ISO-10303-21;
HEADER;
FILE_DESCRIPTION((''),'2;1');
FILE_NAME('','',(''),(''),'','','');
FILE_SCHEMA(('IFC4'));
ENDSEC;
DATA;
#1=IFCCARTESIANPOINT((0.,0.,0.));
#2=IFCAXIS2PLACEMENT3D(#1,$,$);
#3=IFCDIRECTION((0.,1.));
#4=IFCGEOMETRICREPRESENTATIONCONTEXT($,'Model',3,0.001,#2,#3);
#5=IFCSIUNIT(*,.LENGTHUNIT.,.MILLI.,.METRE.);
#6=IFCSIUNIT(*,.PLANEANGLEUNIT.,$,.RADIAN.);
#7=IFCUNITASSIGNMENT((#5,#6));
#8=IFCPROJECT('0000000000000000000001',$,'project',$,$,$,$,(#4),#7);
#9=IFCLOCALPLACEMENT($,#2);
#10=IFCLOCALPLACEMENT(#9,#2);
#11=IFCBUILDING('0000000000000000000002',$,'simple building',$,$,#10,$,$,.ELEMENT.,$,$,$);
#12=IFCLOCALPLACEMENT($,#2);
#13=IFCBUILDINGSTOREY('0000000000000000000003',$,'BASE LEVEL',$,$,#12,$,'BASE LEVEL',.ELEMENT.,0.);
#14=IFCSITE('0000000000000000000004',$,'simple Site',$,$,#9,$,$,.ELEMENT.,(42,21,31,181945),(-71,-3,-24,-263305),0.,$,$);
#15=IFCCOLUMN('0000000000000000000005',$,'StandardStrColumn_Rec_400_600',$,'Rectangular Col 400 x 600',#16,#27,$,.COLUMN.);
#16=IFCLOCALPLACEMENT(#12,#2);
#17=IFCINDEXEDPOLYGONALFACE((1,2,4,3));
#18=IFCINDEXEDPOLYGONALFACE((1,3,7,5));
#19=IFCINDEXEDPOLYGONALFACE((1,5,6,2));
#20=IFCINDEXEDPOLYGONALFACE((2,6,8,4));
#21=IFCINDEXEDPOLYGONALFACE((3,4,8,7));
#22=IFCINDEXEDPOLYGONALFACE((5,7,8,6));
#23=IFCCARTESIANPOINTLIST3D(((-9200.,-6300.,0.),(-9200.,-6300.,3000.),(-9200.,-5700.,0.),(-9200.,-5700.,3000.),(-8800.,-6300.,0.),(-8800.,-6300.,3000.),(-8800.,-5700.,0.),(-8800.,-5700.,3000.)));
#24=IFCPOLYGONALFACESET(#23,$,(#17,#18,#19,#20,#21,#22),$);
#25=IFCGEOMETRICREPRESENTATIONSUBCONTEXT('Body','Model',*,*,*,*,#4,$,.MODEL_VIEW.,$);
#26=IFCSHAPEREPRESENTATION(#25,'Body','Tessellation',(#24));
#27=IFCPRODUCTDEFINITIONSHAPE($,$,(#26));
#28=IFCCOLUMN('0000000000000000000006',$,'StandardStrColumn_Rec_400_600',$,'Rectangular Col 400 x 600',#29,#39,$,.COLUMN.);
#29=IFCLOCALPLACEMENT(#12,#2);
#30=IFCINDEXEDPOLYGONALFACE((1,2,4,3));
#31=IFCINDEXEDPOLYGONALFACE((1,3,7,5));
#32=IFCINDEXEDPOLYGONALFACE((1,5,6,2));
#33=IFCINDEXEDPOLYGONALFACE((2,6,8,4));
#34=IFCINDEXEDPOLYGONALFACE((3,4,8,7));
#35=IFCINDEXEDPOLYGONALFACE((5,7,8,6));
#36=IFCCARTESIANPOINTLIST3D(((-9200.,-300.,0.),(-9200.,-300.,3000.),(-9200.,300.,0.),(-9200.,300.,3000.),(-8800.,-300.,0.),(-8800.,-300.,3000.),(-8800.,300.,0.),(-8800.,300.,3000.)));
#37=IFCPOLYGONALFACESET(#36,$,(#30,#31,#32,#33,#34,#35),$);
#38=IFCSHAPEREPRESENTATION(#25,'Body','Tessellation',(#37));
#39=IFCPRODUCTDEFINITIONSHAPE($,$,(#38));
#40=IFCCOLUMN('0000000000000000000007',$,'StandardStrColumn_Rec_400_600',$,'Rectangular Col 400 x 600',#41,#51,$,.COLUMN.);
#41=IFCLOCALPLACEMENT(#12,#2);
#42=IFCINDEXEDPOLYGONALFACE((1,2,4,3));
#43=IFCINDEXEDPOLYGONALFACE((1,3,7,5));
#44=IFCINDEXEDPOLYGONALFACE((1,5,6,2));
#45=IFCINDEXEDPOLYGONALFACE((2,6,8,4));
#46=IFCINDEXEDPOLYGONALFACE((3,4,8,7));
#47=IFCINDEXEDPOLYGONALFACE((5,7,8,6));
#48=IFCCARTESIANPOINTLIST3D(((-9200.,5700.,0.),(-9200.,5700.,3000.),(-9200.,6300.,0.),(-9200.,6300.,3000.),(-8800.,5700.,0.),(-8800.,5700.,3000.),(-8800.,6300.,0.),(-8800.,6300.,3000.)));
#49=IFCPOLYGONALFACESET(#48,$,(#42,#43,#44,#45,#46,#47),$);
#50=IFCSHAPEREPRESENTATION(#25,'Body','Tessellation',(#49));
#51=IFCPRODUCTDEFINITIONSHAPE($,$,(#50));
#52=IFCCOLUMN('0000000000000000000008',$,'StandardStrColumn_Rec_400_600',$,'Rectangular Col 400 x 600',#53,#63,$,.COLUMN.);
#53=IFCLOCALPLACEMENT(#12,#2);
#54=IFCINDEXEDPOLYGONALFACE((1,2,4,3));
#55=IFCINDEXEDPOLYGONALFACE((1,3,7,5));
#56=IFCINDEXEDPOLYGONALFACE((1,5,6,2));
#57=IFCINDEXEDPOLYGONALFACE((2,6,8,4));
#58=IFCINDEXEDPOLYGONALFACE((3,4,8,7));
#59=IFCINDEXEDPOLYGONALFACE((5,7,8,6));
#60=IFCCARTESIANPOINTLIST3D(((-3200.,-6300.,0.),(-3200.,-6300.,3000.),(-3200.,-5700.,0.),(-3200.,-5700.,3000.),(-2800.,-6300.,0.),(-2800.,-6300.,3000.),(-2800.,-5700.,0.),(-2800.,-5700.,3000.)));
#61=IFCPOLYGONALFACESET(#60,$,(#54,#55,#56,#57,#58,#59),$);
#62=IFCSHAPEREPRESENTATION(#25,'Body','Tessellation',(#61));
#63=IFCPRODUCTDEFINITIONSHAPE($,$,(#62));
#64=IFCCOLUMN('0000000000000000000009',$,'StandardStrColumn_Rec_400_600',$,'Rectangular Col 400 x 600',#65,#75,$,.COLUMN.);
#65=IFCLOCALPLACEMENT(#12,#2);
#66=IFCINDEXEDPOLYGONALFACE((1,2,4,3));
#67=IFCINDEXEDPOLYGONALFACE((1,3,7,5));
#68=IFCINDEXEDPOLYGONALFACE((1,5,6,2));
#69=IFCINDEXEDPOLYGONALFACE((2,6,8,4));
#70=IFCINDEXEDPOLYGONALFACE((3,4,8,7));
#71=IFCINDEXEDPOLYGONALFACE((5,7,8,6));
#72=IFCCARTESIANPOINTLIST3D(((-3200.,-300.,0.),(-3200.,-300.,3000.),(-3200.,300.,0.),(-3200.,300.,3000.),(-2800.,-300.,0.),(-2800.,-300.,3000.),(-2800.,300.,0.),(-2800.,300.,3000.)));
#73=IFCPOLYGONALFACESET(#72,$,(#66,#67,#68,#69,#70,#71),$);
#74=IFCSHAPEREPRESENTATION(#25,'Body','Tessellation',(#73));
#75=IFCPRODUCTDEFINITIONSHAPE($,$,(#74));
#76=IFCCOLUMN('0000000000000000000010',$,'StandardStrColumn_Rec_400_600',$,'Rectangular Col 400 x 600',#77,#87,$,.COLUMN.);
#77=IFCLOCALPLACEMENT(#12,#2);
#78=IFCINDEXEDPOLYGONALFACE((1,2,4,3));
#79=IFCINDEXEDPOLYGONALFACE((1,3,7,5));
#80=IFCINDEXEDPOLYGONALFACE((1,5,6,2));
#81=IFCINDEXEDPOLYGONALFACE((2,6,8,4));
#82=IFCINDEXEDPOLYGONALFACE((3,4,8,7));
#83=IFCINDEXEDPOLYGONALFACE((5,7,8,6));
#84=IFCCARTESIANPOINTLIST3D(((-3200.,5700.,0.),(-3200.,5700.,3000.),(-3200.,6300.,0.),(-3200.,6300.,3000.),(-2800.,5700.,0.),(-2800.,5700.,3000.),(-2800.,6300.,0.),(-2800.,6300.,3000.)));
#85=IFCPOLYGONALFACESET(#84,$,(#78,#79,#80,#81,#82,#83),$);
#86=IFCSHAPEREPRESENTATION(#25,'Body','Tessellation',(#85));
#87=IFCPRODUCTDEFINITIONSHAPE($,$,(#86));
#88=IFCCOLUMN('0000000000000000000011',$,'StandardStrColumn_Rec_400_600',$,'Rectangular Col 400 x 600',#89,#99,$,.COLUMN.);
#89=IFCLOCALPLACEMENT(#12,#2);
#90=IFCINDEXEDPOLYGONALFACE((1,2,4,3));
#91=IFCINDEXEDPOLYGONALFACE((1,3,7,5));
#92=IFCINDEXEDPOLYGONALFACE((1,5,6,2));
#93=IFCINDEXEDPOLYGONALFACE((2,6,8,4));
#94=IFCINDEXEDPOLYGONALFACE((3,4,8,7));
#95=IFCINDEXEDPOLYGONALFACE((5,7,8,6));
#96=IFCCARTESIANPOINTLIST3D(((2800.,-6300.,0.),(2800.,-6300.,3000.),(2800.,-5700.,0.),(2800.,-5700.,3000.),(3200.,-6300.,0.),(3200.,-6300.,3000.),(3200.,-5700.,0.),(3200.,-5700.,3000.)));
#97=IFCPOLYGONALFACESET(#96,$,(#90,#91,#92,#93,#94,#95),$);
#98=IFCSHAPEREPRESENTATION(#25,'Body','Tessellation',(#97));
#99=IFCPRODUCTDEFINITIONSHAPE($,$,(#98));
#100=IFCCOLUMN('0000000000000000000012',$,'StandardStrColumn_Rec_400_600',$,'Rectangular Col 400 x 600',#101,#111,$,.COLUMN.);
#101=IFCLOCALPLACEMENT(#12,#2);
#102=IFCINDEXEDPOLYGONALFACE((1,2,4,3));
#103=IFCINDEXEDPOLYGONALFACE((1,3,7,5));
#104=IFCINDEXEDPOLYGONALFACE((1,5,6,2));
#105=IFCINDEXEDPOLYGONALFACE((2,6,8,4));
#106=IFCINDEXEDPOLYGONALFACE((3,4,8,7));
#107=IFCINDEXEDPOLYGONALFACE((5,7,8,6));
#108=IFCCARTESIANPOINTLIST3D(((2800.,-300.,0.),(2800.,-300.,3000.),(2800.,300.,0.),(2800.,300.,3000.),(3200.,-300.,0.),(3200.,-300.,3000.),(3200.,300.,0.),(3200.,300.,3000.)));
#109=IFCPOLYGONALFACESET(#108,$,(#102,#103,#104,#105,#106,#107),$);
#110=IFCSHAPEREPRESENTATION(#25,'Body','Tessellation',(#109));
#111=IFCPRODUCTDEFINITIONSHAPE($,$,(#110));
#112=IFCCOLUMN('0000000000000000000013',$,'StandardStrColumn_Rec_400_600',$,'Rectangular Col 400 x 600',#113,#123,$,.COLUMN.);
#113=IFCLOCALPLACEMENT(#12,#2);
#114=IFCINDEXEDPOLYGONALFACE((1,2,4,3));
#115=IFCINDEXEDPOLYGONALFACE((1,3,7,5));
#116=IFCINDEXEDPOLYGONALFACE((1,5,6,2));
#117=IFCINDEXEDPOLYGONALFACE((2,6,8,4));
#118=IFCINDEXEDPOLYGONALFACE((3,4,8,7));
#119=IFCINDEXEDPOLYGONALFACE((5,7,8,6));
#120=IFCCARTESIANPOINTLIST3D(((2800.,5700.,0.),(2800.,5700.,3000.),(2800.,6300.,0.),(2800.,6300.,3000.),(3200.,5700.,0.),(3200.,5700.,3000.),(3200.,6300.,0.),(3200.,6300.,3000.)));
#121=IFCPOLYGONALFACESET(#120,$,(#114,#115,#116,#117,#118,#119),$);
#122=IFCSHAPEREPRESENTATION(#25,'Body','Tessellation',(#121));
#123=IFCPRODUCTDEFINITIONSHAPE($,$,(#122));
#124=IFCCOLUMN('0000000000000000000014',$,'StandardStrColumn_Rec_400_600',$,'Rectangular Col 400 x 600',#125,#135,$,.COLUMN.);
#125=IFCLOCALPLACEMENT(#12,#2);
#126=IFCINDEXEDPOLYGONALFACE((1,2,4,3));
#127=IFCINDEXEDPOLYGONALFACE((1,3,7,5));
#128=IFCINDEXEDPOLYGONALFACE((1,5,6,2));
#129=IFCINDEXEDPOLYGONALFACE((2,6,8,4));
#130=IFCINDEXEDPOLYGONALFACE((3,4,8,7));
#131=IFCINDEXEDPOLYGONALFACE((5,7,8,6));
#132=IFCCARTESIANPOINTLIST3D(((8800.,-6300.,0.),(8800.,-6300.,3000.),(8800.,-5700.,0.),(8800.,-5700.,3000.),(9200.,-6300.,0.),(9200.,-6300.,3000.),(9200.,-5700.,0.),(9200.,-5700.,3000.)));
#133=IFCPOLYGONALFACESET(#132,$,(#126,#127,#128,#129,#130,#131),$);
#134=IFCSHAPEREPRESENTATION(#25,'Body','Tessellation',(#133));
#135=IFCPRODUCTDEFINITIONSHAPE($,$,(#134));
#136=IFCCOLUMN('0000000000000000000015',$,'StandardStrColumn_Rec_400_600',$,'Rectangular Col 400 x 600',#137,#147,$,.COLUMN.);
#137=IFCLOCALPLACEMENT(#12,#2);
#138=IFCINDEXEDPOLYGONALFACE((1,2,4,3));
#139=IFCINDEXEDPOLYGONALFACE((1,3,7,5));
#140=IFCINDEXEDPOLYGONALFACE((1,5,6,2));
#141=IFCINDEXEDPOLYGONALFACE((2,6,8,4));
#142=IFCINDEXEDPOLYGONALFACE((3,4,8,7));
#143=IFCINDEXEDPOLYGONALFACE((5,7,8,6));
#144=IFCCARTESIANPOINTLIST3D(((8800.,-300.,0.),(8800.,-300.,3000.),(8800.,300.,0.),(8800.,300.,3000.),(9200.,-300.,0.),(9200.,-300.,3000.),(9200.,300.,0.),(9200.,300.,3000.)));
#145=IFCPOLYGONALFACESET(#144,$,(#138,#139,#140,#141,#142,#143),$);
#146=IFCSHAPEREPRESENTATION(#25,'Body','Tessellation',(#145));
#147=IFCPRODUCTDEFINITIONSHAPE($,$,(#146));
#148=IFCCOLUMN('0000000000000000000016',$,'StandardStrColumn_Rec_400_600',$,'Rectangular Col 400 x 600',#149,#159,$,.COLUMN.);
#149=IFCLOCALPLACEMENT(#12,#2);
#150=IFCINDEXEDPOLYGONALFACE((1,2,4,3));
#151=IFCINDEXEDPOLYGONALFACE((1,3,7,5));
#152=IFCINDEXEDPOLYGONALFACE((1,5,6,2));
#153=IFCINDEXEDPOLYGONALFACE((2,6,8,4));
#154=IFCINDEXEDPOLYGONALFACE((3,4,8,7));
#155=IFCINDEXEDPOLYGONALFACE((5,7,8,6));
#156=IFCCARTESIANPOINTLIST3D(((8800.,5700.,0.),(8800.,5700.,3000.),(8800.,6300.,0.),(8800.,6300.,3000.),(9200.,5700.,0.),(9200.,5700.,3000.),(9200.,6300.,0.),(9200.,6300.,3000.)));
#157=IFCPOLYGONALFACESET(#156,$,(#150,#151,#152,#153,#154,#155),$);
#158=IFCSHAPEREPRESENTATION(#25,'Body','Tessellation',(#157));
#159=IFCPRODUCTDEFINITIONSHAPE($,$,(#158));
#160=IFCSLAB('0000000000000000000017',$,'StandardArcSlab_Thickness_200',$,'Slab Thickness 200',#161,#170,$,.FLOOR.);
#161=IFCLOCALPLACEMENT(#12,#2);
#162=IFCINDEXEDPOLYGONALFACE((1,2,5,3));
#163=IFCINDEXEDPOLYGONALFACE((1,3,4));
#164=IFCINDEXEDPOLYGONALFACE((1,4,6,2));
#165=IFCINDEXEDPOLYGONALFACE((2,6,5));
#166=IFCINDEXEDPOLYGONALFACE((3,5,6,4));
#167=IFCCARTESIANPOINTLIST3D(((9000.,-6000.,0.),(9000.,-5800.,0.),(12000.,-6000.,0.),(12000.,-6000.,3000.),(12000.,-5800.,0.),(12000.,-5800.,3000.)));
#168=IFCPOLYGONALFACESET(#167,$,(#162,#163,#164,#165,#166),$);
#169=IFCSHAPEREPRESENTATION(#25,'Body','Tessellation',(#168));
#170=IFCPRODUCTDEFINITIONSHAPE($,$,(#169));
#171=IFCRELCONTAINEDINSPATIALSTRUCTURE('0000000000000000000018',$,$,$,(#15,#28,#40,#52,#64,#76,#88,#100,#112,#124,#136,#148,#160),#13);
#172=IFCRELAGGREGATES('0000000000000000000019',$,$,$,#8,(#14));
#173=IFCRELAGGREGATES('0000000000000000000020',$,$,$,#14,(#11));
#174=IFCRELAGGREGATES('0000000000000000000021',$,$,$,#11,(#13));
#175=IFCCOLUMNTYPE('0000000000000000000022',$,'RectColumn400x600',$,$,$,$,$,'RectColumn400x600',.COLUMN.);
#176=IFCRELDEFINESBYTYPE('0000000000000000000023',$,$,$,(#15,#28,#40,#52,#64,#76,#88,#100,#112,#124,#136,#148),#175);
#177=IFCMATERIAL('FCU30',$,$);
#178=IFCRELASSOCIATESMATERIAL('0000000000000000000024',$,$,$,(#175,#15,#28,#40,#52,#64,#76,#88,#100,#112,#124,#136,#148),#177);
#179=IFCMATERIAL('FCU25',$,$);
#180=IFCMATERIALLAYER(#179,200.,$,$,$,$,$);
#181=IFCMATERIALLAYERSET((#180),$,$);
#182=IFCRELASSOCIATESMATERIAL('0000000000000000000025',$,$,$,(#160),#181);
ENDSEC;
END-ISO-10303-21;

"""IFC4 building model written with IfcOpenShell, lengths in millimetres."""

from ifc_helpers import new_model, si_unit, direction, frame, origin, origin_with_axes, origin_2d_with_axis, place, context, subcontext, project, spatial, polyline, rectangle, outline, extrude, material, layer, layer_set, layer_usage, material_profile, profile_set, profile_usage, type_object, element, save


model = new_model("IFC4")

# Units and contexts
model_context = context("Model", 3, precision=0.001, world=origin(), true_north=direction((0.0, 1.0)))
body_context = subcontext(model_context, "Body", "Model", "MODEL_VIEW")
ifc_project = project(units=[si_unit("LENGTHUNIT", "METRE", prefix="MILLI"), si_unit("PLANEANGLEUNIT", "RADIAN")], contexts=[model_context])

# Site, building, storey
site_placement = place(None, origin())
site = spatial("IfcSite", under=ifc_project, at=site_placement, Name="simple Site", CompositionType="ELEMENT", RefLatitude=(42, 21, 31, 181945), RefLongitude=(-71, -3, -24, -263305), RefElevation=0.0)
building_placement = place(site_placement, origin())
building = spatial("IfcBuilding", under=site, at=building_placement, Name="simple building", CompositionType="ELEMENT")
storey_placement = place(None, origin())
storey = spatial("IfcBuildingStorey", under=building, at=storey_placement, Name="BASE LEVEL", LongName="BASE LEVEL", CompositionType="ELEMENT", Elevation=0.0)

# Columns
ifc_material_1 = material(Name="FCU30")
ifc_material_profile = material_profile(ifc_material_1, rectangle(XDim=400.0, YDim=600.0, at=origin_2d_with_axis()))
ifc_profile_set = profile_set([ifc_material_profile])
ifc_profile_usage = profile_usage(ifc_profile_set, cardinal=10)
column_type = type_object("IfcColumnType", Name="RectColumn400x600", ElementType="RectColumn400x600", PredefinedType="COLUMN", material=ifc_profile_usage)
for number, where, z_axis, x_axis, name in (
    (1, (-9000.0, -6000.0, 0.0), (0.0, 0.0, 1.0), (1.0, 0.0, 0.0), "StandardStrColumn_Rec_400_600"),
    (2, (-9000.0, 0.0, 0.0), (0.0, 0.0, 1.0), (1.0, 0.0, 0.0), "StandardStrColumn_Rec_400_600"),
    (3, (-9000.0, 6000.0, 0.0), (0.0, 0.0, 1.0), (1.0, 0.0, 0.0), "StandardStrColumn_Rec_400_600"),
    (4, (-3000.0, -6000.0, 0.0), (0.0, 0.0, 1.0), (1.0, 0.0, 0.0), "StandardStrColumn_Rec_400_600"),
    (5, (-3000.0, 0.0, 0.0), (0.0, 0.0, 1.0), (1.0, 0.0, 0.0), "StandardStrColumn_Rec_400_600"),
    (6, (-3000.0, 6000.0, 0.0), (0.0, 0.0, 1.0), (1.0, 0.0, 0.0), "StandardStrColumn_Rec_400_600"),
    (7, (3000.0, -6000.0, 0.0), (0.0, 0.0, 1.0), (1.0, 0.0, 0.0), "StandardStrColumn_Rec_400_600"),
    (8, (3000.0, 0.0, 0.0), (0.0, 0.0, 1.0), (1.0, 0.0, 0.0), "StandardStrColumn_Rec_400_600"),
    (9, (3000.0, 6000.0, 0.0), (0.0, 0.0, 1.0), (1.0, 0.0, 0.0), "StandardStrColumn_Rec_400_600"),
    (10, (9000.0, -6000.0, 0.0), (0.0, 0.0, 1.0), (1.0, 0.0, 0.0), "StandardStrColumn_Rec_400_600"),
    (11, (9000.0, 0.0, 0.0), (0.0, 0.0, 1.0), (1.0, 0.0, 0.0), "StandardStrColumn_Rec_400_600"),
    (12, (9000.0, 6000.0, 0.0), (0.0, 0.0, 1.0), (1.0, 0.0, 0.0), "StandardStrColumn_Rec_400_600"),
):
    element("IfcColumn", number, at=place(None, frame(where, z_axis=z_axis, x_axis=x_axis)), inside=storey, type_object=column_type, material=ifc_profile_usage, Name=name, ObjectType="Rectangular Col 400 x 600", PredefinedType="COLUMN", context=body_context, shape_type="SweptSolid", body=[
        extrude(rectangle(XDim=400.0, YDim=600.0, at=origin_2d_with_axis()), origin_with_axes(), (0.0, 0.0, 1.0), 3000.0),
    ])

# Slab
ifc_material_2 = material(Name="FCU25")
ifc_layer = layer(ifc_material_2, 200.0)
ifc_layer_set = layer_set([ifc_layer])
ifc_layer_usage = layer_usage(ifc_layer_set, "AXIS3", "POSITIVE", -200.0)
slab_placement = place(None, frame((9000.0, -5800.0, 0.0), z_axis=(0.0, -1.0, 0.0), x_axis=(1.0, 0.0, 0.0)))
element("IfcSlab", 13, at=slab_placement, inside=storey, material=ifc_layer_usage, Name="StandardArcSlab_Thickness_200", ObjectType="Slab Thickness 200", PredefinedType="FLOOR", context=body_context, shape_type="SweptSolid", body=[
    extrude(outline(polyline([(0.0, 0.0), (3000.0, 0.0), (3000.0, 3000.0), (0.0, 0.0)])), origin_with_axes(), (0.0, 0.0, 1.0), 200.0),
])

save(model, "model.ifc")
